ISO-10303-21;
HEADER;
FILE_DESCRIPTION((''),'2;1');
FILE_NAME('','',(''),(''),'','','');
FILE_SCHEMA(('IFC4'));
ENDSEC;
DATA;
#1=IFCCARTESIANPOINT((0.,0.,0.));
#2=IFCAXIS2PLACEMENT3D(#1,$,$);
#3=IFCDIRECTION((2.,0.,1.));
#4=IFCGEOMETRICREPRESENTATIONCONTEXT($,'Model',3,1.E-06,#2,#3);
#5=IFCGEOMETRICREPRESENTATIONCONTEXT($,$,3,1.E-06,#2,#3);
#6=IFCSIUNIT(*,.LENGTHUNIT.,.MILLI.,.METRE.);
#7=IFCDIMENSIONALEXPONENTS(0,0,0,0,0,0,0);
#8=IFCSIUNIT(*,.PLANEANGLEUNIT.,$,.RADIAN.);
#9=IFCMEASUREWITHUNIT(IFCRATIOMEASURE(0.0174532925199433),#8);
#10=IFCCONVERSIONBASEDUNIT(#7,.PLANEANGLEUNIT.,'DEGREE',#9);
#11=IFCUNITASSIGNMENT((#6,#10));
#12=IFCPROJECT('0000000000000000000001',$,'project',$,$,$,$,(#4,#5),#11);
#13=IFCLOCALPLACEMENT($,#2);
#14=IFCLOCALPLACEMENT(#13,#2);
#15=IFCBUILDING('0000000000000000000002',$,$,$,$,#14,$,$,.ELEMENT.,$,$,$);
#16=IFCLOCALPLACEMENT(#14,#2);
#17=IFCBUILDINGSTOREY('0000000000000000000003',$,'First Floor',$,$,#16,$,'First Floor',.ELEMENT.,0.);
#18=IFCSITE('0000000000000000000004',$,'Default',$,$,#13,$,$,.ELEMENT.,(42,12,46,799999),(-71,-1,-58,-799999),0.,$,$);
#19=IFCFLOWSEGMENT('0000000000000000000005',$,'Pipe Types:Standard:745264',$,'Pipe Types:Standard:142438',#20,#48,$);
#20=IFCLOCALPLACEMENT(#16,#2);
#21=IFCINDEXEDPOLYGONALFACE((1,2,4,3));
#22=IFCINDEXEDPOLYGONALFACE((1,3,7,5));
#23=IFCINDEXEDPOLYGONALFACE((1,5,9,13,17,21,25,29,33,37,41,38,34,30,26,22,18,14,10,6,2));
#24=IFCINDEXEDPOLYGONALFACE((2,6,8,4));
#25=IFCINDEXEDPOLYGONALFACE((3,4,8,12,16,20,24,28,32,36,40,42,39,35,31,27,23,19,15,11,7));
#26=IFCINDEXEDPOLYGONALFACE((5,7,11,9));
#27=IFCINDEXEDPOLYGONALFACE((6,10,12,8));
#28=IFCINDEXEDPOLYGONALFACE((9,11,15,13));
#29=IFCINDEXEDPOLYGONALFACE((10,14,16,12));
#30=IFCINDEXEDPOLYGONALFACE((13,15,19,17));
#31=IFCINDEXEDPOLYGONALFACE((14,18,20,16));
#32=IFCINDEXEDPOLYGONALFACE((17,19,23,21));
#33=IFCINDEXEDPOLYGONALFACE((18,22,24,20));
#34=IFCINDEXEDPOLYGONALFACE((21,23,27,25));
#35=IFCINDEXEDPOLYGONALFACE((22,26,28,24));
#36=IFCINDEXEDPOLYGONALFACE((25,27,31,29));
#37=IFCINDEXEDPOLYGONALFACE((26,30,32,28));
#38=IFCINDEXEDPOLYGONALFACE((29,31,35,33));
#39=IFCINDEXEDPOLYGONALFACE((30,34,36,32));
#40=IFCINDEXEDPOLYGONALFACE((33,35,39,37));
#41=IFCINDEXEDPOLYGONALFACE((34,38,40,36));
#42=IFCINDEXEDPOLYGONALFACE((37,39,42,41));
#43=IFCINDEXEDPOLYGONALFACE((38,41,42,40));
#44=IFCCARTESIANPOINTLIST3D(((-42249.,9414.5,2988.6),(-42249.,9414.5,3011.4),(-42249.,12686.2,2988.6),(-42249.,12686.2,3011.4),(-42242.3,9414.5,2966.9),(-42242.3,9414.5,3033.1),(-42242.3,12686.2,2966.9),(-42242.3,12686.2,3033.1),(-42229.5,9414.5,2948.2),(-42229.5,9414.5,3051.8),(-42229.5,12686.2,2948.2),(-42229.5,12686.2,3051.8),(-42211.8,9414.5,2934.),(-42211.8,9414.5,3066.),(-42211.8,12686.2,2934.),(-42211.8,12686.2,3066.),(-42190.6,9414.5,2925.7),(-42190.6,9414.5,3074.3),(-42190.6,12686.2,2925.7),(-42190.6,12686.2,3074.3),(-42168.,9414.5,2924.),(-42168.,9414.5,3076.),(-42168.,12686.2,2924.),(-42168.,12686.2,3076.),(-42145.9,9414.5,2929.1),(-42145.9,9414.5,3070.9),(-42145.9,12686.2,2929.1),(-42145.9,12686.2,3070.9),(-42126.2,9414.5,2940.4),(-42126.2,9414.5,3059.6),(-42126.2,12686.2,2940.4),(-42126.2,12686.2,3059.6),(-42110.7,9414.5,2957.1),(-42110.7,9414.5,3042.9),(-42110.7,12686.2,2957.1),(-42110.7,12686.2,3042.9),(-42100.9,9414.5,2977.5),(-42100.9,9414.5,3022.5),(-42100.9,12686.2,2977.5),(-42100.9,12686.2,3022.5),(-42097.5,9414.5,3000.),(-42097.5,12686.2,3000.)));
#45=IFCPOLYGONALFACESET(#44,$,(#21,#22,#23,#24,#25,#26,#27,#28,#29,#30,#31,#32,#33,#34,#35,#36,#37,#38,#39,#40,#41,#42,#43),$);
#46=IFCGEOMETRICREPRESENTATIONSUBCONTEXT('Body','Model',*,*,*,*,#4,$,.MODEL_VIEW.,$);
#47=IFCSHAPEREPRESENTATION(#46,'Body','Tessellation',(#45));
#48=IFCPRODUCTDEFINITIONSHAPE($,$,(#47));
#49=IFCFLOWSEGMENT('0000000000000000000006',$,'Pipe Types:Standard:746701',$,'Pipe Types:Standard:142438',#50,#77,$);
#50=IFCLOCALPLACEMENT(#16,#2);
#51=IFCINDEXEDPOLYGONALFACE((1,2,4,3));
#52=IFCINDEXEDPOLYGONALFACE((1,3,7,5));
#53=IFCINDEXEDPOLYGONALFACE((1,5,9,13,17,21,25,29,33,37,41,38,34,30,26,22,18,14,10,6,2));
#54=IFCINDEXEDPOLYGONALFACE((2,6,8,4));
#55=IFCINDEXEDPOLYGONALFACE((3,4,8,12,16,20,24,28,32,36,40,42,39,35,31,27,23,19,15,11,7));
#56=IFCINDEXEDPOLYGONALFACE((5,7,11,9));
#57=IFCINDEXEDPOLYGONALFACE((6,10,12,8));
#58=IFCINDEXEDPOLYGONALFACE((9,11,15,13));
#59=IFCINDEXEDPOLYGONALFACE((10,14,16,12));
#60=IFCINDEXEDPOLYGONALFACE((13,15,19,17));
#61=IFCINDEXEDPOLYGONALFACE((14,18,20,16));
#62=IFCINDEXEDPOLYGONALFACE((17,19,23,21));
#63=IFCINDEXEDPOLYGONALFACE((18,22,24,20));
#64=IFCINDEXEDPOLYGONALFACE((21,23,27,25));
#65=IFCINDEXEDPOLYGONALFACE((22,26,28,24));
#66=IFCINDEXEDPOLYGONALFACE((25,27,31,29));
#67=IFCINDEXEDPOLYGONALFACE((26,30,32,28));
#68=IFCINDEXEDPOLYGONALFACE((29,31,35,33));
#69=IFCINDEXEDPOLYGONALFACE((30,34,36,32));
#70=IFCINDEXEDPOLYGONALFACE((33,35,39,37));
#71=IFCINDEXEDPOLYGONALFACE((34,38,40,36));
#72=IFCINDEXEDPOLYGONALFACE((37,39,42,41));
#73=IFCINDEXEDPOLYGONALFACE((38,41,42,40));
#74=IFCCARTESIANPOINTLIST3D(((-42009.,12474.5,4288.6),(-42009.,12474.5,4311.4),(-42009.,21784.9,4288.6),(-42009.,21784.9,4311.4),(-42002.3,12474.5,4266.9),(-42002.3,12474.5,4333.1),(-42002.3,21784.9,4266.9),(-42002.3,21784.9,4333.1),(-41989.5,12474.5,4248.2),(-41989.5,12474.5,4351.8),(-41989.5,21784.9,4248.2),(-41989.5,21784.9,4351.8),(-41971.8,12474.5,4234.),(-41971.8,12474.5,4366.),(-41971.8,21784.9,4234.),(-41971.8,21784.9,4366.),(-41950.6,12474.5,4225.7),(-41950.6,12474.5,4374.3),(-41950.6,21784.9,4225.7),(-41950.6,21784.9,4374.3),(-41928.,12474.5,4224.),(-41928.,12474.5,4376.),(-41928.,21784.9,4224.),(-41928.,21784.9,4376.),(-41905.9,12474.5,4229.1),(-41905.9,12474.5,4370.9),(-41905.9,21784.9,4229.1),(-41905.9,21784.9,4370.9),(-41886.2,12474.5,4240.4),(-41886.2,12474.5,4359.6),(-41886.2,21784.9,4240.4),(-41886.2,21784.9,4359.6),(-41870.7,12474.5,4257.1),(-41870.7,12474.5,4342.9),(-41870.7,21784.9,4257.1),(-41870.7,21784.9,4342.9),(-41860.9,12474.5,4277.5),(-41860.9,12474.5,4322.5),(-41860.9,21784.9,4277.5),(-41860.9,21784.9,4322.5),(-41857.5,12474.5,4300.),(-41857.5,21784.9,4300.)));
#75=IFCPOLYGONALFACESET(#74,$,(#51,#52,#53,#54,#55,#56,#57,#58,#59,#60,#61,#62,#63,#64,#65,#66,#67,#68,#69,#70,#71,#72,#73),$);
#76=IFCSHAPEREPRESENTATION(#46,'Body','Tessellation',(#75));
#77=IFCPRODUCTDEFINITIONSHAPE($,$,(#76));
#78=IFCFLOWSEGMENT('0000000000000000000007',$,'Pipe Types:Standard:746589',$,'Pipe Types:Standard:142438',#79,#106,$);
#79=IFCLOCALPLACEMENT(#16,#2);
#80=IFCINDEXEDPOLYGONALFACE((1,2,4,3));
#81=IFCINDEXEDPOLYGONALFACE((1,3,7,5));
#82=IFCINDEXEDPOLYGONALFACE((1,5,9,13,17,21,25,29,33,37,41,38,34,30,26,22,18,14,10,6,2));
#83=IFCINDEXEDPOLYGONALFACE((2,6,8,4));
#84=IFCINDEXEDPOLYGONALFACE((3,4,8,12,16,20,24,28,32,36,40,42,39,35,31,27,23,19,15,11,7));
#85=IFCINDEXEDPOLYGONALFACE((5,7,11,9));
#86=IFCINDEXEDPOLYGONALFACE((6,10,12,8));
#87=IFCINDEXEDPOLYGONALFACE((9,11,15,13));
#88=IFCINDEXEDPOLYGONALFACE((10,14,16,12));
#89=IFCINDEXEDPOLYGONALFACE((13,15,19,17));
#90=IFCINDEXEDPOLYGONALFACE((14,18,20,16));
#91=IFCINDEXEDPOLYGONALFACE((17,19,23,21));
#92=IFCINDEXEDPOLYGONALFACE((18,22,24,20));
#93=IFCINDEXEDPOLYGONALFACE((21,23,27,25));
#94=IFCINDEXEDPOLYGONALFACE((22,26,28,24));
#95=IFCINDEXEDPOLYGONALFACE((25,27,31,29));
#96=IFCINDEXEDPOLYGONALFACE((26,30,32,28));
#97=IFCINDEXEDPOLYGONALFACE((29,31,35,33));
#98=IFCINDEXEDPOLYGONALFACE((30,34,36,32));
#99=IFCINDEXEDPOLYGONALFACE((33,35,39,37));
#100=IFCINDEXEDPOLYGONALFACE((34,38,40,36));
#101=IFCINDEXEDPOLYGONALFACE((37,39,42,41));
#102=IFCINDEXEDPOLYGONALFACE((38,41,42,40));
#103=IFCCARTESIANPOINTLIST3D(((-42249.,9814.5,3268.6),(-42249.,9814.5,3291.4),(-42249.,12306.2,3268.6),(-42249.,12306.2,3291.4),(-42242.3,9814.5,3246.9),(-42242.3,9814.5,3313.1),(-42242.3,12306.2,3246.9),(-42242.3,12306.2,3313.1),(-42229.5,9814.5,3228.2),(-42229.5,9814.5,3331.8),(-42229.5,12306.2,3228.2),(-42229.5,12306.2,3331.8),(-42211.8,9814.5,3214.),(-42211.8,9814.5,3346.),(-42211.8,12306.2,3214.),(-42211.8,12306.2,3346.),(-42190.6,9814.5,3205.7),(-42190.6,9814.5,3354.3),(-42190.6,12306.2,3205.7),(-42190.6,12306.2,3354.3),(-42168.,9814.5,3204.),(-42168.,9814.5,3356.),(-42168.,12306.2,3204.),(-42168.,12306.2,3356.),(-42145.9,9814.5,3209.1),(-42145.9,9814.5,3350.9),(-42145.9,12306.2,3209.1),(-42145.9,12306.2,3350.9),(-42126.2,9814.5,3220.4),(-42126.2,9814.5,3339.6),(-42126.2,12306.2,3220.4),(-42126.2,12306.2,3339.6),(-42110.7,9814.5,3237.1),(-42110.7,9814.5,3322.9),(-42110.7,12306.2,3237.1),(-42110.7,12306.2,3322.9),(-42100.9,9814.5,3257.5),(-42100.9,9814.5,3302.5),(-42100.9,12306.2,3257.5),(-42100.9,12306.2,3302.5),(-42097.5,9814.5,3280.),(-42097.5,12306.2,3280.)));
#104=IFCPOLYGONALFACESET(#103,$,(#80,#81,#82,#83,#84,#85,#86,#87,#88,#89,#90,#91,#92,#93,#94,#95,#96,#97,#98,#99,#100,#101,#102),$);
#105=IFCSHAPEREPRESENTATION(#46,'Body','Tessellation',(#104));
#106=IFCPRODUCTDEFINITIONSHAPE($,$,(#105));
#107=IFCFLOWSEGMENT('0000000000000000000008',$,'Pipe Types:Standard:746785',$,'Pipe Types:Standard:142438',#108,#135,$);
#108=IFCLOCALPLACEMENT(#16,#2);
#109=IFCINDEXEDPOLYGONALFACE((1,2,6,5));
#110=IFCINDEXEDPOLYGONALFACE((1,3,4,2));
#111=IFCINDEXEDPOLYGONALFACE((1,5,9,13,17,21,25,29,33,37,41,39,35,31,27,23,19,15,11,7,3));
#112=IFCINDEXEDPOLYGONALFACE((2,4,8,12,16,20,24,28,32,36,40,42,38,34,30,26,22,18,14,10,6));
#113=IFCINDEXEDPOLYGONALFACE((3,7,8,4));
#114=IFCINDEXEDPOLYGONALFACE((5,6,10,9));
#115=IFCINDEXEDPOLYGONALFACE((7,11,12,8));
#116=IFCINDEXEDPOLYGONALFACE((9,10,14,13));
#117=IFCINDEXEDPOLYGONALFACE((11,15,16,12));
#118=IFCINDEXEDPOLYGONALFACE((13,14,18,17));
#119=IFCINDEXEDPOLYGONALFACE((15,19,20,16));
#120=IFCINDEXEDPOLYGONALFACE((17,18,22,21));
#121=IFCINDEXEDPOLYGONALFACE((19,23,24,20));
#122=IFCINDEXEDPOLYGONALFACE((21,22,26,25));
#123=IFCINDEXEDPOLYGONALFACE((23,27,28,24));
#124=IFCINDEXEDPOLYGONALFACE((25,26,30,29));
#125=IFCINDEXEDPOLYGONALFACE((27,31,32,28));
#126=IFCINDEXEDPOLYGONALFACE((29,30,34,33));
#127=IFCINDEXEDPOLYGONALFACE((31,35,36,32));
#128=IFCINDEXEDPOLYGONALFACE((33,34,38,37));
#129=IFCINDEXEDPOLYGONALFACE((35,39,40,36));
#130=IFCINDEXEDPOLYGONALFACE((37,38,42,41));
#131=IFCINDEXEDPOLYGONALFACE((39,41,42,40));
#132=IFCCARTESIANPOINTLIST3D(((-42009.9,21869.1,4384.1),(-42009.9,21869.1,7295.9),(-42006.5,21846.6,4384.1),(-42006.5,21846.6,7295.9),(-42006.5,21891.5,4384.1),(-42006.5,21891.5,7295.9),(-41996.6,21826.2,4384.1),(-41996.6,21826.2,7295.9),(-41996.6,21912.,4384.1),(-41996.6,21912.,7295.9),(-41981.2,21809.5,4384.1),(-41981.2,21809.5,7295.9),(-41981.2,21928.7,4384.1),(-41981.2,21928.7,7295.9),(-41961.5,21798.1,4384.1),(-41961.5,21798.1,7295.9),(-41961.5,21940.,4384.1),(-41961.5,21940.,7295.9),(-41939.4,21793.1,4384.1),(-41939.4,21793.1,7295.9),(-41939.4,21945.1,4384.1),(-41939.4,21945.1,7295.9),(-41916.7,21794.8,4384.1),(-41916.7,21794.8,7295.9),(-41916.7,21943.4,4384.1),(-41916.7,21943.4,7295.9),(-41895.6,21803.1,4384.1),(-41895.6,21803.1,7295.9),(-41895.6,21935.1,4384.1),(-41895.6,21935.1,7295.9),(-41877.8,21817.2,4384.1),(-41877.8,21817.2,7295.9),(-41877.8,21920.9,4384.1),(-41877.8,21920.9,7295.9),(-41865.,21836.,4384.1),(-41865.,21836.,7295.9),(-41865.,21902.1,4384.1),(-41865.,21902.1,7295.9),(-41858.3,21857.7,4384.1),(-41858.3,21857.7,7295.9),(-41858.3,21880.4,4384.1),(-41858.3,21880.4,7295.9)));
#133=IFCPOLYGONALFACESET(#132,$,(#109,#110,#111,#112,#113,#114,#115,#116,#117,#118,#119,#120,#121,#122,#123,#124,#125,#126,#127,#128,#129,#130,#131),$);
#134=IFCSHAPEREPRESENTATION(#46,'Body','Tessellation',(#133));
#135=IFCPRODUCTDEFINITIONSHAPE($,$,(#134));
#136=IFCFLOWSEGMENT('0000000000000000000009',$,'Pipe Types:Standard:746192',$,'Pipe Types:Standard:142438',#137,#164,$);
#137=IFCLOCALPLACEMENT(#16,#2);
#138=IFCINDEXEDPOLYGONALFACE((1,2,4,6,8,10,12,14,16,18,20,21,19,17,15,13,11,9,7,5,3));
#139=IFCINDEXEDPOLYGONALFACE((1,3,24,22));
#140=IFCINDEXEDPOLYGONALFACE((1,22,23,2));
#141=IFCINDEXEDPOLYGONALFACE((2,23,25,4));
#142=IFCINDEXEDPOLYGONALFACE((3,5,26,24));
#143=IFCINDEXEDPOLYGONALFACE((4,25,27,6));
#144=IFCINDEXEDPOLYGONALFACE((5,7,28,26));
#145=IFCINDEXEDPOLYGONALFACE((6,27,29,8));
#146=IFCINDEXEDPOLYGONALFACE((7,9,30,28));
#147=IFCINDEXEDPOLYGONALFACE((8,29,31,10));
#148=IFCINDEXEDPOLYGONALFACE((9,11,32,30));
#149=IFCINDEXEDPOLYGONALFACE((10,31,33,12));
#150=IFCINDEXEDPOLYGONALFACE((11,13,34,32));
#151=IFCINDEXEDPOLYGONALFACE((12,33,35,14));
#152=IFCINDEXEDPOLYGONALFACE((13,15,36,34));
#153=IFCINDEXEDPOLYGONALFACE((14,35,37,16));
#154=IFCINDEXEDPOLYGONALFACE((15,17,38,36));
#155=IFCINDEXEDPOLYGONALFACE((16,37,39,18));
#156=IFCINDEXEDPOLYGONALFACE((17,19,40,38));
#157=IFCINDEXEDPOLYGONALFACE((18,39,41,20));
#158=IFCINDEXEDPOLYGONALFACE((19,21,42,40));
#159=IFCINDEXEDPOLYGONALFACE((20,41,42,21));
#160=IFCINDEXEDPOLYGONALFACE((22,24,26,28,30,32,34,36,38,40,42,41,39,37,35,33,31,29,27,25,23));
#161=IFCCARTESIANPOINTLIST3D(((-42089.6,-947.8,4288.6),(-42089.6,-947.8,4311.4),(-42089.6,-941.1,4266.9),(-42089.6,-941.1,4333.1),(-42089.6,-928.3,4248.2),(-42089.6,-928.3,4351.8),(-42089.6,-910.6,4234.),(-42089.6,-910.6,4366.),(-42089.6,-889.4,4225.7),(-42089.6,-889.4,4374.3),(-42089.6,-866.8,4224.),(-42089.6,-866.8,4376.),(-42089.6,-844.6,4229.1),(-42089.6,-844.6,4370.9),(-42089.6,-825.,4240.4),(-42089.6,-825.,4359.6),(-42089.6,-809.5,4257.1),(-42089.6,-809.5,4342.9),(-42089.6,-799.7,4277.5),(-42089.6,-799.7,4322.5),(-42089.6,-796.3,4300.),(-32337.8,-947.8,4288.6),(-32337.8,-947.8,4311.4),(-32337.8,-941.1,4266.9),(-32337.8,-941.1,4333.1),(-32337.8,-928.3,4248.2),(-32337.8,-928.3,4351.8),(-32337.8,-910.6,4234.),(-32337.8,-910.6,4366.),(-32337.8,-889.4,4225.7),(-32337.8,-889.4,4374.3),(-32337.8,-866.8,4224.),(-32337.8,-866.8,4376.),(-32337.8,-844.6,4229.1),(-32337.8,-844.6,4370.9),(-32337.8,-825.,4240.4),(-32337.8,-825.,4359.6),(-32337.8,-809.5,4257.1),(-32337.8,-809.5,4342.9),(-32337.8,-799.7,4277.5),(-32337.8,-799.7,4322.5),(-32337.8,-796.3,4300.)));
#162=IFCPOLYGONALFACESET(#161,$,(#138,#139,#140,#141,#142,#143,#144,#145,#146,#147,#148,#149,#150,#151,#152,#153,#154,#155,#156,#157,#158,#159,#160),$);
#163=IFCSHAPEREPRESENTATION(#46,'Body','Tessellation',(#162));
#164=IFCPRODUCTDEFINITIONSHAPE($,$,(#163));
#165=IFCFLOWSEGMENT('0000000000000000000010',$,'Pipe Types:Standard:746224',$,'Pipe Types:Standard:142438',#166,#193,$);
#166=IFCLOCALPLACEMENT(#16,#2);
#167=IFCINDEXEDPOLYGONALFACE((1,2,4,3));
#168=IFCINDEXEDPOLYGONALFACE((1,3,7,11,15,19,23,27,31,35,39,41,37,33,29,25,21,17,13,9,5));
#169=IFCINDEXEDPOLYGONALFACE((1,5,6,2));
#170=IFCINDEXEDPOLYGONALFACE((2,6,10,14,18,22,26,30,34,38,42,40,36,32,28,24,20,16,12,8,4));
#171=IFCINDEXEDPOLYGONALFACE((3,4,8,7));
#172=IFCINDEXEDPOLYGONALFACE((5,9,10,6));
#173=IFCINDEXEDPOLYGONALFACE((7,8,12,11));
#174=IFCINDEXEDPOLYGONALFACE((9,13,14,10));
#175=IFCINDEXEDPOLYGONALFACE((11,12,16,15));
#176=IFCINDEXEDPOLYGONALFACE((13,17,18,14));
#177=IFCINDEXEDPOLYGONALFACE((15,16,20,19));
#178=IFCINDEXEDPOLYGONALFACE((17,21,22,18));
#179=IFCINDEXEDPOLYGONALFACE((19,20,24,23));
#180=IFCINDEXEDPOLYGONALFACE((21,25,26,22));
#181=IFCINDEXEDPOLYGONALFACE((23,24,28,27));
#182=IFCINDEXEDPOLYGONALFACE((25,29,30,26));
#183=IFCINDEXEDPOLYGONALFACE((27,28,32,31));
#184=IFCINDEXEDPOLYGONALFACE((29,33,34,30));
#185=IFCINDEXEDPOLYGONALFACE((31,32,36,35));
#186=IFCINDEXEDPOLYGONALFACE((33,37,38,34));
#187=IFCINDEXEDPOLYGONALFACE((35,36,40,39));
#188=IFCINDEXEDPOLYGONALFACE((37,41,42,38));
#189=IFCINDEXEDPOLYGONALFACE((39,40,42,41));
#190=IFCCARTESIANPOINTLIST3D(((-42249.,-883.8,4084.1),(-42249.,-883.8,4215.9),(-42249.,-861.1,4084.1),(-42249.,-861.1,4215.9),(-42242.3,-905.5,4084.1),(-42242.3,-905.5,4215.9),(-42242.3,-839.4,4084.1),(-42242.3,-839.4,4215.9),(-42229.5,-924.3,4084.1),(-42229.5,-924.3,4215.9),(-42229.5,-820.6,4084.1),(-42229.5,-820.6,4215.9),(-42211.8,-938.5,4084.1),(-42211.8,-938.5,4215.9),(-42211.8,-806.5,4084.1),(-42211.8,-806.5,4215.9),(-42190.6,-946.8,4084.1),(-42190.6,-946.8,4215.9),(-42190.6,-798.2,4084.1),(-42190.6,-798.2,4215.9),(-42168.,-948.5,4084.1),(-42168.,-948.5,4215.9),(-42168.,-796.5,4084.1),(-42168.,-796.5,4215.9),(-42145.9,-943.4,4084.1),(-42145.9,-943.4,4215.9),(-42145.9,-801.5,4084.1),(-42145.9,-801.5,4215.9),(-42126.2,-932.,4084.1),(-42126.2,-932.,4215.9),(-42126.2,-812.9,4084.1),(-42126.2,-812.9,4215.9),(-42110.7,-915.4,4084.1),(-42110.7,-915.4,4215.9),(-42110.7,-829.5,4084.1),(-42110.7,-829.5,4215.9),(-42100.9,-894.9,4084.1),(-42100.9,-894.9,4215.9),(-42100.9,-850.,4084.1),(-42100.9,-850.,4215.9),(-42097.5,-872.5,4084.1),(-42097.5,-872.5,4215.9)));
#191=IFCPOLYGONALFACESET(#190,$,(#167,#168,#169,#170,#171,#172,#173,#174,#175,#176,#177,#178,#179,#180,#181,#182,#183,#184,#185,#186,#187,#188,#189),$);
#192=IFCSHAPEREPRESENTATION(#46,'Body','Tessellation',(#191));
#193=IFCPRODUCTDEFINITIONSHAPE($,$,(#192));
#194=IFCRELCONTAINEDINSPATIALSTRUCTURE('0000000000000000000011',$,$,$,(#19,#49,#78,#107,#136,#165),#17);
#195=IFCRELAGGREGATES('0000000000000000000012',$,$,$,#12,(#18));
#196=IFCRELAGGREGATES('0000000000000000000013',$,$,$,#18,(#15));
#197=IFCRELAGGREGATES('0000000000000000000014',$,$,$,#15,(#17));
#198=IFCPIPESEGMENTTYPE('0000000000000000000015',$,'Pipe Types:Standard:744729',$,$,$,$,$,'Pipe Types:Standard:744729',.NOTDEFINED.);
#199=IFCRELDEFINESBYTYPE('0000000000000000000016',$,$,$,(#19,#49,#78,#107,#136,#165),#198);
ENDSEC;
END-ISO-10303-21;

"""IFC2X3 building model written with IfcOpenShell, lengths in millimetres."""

from ifc_helpers import new_model, entity, si_unit, converted_unit, direction, frame, frame_2d, origin, origin_2d_with_axis, place, context, subcontext, project, spatial, circle, extrude, type_object, element, save


model = new_model("IFC2X3")

# Units and contexts
model_context = context("Model", 3, precision=1e-06, world=origin(), true_north=direction((2.0, 0.0, 1.0)))
context_of_model = context(None, 3, precision=1e-06, world=origin(), true_north=direction((2.0, 0.0, 1.0)))
body_context = subcontext(model_context, "Body", "Model", "MODEL_VIEW")
ifc_project = project(units=[si_unit("LENGTHUNIT", "METRE", prefix="MILLI"), converted_unit("PLANEANGLEUNIT", "DEGREE", entity("IfcRatioMeasure", 0.0174532925199433), si_unit("PLANEANGLEUNIT", "RADIAN"), dimensions=[0, 0, 0, 0, 0, 0, 0])], contexts=[model_context, context_of_model])

# Site, building, storey
site_placement = place(None, origin())
site = spatial("IfcSite", under=ifc_project, at=site_placement, Name="Default", CompositionType="ELEMENT", RefLatitude=(42, 12, 46, 799999), RefLongitude=(-71, -1, -58, -799999), RefElevation=0.0)
building_placement = place(site_placement, origin())
building = spatial("IfcBuilding", under=site, at=building_placement, CompositionType="ELEMENT")
storey_placement = place(building_placement, origin())
storey = spatial("IfcBuildingStorey", under=building, at=storey_placement, Name="First Floor", LongName="First Floor", CompositionType="ELEMENT", Elevation=0.0)

# Flow segments
pipe_segment_type = type_object("IfcPipeSegmentType", Name="Pipe Types:Standard:744729", ElementType="Pipe Types:Standard:744729", PredefinedType="NOTDEFINED")
flow_segment_1_placement = place(storey_placement, origin())
element("IfcFlowSegment", 1, at=flow_segment_1_placement, inside=storey, type_object=pipe_segment_type, Name="Pipe Types:Standard:745264", ObjectType="Pipe Types:Standard:142438", context=body_context, shape_type="SweptSolid", body=[
    extrude(circle(Radius=76.2, at=origin_2d_with_axis()), frame((-42173.7, 9414.5, 3000.0), z_axis=(0.0, 1.0, 0.0), x_axis=(1.0, 0.0, 0.0)), (0.0, 0.0, 1.0), 3271.7),
])
flow_segment_2_placement = place(storey_placement, origin())
element("IfcFlowSegment", 2, at=flow_segment_2_placement, inside=storey, type_object=pipe_segment_type, Name="Pipe Types:Standard:746701", ObjectType="Pipe Types:Standard:142438", context=body_context, shape_type="SweptSolid", body=[
    extrude(circle(Radius=76.2, at=origin_2d_with_axis()), frame((-41933.7, 12474.5, 4300.0), z_axis=(0.0, 1.0, 0.0), x_axis=(1.0, 0.0, 0.0)), (0.0, 0.0, 1.0), 9310.5),
])
flow_segment_3_placement = place(storey_placement, origin())
element("IfcFlowSegment", 3, at=flow_segment_3_placement, inside=storey, type_object=pipe_segment_type, Name="Pipe Types:Standard:746589", ObjectType="Pipe Types:Standard:142438", context=body_context, shape_type="SweptSolid", body=[
    extrude(circle(Radius=76.2, at=origin_2d_with_axis()), frame((-42173.7, 9814.5, 3280.0), z_axis=(0.0, 1.0, 0.0), x_axis=(1.0, 0.0, 0.0)), (0.0, 0.0, 1.0), 2491.7),
])
flow_segment_4_placement = place(storey_placement, origin())
element("IfcFlowSegment", 4, at=flow_segment_4_placement, inside=storey, type_object=pipe_segment_type, Name="Pipe Types:Standard:746785", ObjectType="Pipe Types:Standard:142438", context=body_context, shape_type="SweptSolid", body=[
    extrude(circle(Radius=76.2, at=origin_2d_with_axis()), frame((-41933.7, 21869.1, 4384.1), z_axis=(0.0, 0.0, 1.0), x_axis=(-1.0, 0.0, 0.0)), (0.0, 0.0, 1.0), 2911.7),
])
flow_segment_5_placement = place(storey_placement, origin())
element("IfcFlowSegment", 5, at=flow_segment_5_placement, inside=storey, type_object=pipe_segment_type, Name="Pipe Types:Standard:746192", ObjectType="Pipe Types:Standard:142438", context=body_context, shape_type="SweptSolid", body=[
    extrude(circle(Radius=76.2, at=frame_2d((0.0, 0.0), x_axis=(1.0, 0.0))), frame((-42089.6, -872.5, 4300.0), z_axis=(1.0, 0.0, 0.0), x_axis=(0.0, 1.0, 0.0)), (0.0, 0.0, 1.0), 9751.7),
])
flow_segment_6_placement = place(storey_placement, origin())
element("IfcFlowSegment", 6, at=flow_segment_6_placement, inside=storey, type_object=pipe_segment_type, Name="Pipe Types:Standard:746224", ObjectType="Pipe Types:Standard:142438", context=body_context, shape_type="SweptSolid", body=[
    extrude(circle(Radius=76.2, at=origin_2d_with_axis()), frame((-42173.7, -872.5, 4084.1)), (0.0, 0.0, 1.0), 131.7),
])

save(model, "model.ifc")
